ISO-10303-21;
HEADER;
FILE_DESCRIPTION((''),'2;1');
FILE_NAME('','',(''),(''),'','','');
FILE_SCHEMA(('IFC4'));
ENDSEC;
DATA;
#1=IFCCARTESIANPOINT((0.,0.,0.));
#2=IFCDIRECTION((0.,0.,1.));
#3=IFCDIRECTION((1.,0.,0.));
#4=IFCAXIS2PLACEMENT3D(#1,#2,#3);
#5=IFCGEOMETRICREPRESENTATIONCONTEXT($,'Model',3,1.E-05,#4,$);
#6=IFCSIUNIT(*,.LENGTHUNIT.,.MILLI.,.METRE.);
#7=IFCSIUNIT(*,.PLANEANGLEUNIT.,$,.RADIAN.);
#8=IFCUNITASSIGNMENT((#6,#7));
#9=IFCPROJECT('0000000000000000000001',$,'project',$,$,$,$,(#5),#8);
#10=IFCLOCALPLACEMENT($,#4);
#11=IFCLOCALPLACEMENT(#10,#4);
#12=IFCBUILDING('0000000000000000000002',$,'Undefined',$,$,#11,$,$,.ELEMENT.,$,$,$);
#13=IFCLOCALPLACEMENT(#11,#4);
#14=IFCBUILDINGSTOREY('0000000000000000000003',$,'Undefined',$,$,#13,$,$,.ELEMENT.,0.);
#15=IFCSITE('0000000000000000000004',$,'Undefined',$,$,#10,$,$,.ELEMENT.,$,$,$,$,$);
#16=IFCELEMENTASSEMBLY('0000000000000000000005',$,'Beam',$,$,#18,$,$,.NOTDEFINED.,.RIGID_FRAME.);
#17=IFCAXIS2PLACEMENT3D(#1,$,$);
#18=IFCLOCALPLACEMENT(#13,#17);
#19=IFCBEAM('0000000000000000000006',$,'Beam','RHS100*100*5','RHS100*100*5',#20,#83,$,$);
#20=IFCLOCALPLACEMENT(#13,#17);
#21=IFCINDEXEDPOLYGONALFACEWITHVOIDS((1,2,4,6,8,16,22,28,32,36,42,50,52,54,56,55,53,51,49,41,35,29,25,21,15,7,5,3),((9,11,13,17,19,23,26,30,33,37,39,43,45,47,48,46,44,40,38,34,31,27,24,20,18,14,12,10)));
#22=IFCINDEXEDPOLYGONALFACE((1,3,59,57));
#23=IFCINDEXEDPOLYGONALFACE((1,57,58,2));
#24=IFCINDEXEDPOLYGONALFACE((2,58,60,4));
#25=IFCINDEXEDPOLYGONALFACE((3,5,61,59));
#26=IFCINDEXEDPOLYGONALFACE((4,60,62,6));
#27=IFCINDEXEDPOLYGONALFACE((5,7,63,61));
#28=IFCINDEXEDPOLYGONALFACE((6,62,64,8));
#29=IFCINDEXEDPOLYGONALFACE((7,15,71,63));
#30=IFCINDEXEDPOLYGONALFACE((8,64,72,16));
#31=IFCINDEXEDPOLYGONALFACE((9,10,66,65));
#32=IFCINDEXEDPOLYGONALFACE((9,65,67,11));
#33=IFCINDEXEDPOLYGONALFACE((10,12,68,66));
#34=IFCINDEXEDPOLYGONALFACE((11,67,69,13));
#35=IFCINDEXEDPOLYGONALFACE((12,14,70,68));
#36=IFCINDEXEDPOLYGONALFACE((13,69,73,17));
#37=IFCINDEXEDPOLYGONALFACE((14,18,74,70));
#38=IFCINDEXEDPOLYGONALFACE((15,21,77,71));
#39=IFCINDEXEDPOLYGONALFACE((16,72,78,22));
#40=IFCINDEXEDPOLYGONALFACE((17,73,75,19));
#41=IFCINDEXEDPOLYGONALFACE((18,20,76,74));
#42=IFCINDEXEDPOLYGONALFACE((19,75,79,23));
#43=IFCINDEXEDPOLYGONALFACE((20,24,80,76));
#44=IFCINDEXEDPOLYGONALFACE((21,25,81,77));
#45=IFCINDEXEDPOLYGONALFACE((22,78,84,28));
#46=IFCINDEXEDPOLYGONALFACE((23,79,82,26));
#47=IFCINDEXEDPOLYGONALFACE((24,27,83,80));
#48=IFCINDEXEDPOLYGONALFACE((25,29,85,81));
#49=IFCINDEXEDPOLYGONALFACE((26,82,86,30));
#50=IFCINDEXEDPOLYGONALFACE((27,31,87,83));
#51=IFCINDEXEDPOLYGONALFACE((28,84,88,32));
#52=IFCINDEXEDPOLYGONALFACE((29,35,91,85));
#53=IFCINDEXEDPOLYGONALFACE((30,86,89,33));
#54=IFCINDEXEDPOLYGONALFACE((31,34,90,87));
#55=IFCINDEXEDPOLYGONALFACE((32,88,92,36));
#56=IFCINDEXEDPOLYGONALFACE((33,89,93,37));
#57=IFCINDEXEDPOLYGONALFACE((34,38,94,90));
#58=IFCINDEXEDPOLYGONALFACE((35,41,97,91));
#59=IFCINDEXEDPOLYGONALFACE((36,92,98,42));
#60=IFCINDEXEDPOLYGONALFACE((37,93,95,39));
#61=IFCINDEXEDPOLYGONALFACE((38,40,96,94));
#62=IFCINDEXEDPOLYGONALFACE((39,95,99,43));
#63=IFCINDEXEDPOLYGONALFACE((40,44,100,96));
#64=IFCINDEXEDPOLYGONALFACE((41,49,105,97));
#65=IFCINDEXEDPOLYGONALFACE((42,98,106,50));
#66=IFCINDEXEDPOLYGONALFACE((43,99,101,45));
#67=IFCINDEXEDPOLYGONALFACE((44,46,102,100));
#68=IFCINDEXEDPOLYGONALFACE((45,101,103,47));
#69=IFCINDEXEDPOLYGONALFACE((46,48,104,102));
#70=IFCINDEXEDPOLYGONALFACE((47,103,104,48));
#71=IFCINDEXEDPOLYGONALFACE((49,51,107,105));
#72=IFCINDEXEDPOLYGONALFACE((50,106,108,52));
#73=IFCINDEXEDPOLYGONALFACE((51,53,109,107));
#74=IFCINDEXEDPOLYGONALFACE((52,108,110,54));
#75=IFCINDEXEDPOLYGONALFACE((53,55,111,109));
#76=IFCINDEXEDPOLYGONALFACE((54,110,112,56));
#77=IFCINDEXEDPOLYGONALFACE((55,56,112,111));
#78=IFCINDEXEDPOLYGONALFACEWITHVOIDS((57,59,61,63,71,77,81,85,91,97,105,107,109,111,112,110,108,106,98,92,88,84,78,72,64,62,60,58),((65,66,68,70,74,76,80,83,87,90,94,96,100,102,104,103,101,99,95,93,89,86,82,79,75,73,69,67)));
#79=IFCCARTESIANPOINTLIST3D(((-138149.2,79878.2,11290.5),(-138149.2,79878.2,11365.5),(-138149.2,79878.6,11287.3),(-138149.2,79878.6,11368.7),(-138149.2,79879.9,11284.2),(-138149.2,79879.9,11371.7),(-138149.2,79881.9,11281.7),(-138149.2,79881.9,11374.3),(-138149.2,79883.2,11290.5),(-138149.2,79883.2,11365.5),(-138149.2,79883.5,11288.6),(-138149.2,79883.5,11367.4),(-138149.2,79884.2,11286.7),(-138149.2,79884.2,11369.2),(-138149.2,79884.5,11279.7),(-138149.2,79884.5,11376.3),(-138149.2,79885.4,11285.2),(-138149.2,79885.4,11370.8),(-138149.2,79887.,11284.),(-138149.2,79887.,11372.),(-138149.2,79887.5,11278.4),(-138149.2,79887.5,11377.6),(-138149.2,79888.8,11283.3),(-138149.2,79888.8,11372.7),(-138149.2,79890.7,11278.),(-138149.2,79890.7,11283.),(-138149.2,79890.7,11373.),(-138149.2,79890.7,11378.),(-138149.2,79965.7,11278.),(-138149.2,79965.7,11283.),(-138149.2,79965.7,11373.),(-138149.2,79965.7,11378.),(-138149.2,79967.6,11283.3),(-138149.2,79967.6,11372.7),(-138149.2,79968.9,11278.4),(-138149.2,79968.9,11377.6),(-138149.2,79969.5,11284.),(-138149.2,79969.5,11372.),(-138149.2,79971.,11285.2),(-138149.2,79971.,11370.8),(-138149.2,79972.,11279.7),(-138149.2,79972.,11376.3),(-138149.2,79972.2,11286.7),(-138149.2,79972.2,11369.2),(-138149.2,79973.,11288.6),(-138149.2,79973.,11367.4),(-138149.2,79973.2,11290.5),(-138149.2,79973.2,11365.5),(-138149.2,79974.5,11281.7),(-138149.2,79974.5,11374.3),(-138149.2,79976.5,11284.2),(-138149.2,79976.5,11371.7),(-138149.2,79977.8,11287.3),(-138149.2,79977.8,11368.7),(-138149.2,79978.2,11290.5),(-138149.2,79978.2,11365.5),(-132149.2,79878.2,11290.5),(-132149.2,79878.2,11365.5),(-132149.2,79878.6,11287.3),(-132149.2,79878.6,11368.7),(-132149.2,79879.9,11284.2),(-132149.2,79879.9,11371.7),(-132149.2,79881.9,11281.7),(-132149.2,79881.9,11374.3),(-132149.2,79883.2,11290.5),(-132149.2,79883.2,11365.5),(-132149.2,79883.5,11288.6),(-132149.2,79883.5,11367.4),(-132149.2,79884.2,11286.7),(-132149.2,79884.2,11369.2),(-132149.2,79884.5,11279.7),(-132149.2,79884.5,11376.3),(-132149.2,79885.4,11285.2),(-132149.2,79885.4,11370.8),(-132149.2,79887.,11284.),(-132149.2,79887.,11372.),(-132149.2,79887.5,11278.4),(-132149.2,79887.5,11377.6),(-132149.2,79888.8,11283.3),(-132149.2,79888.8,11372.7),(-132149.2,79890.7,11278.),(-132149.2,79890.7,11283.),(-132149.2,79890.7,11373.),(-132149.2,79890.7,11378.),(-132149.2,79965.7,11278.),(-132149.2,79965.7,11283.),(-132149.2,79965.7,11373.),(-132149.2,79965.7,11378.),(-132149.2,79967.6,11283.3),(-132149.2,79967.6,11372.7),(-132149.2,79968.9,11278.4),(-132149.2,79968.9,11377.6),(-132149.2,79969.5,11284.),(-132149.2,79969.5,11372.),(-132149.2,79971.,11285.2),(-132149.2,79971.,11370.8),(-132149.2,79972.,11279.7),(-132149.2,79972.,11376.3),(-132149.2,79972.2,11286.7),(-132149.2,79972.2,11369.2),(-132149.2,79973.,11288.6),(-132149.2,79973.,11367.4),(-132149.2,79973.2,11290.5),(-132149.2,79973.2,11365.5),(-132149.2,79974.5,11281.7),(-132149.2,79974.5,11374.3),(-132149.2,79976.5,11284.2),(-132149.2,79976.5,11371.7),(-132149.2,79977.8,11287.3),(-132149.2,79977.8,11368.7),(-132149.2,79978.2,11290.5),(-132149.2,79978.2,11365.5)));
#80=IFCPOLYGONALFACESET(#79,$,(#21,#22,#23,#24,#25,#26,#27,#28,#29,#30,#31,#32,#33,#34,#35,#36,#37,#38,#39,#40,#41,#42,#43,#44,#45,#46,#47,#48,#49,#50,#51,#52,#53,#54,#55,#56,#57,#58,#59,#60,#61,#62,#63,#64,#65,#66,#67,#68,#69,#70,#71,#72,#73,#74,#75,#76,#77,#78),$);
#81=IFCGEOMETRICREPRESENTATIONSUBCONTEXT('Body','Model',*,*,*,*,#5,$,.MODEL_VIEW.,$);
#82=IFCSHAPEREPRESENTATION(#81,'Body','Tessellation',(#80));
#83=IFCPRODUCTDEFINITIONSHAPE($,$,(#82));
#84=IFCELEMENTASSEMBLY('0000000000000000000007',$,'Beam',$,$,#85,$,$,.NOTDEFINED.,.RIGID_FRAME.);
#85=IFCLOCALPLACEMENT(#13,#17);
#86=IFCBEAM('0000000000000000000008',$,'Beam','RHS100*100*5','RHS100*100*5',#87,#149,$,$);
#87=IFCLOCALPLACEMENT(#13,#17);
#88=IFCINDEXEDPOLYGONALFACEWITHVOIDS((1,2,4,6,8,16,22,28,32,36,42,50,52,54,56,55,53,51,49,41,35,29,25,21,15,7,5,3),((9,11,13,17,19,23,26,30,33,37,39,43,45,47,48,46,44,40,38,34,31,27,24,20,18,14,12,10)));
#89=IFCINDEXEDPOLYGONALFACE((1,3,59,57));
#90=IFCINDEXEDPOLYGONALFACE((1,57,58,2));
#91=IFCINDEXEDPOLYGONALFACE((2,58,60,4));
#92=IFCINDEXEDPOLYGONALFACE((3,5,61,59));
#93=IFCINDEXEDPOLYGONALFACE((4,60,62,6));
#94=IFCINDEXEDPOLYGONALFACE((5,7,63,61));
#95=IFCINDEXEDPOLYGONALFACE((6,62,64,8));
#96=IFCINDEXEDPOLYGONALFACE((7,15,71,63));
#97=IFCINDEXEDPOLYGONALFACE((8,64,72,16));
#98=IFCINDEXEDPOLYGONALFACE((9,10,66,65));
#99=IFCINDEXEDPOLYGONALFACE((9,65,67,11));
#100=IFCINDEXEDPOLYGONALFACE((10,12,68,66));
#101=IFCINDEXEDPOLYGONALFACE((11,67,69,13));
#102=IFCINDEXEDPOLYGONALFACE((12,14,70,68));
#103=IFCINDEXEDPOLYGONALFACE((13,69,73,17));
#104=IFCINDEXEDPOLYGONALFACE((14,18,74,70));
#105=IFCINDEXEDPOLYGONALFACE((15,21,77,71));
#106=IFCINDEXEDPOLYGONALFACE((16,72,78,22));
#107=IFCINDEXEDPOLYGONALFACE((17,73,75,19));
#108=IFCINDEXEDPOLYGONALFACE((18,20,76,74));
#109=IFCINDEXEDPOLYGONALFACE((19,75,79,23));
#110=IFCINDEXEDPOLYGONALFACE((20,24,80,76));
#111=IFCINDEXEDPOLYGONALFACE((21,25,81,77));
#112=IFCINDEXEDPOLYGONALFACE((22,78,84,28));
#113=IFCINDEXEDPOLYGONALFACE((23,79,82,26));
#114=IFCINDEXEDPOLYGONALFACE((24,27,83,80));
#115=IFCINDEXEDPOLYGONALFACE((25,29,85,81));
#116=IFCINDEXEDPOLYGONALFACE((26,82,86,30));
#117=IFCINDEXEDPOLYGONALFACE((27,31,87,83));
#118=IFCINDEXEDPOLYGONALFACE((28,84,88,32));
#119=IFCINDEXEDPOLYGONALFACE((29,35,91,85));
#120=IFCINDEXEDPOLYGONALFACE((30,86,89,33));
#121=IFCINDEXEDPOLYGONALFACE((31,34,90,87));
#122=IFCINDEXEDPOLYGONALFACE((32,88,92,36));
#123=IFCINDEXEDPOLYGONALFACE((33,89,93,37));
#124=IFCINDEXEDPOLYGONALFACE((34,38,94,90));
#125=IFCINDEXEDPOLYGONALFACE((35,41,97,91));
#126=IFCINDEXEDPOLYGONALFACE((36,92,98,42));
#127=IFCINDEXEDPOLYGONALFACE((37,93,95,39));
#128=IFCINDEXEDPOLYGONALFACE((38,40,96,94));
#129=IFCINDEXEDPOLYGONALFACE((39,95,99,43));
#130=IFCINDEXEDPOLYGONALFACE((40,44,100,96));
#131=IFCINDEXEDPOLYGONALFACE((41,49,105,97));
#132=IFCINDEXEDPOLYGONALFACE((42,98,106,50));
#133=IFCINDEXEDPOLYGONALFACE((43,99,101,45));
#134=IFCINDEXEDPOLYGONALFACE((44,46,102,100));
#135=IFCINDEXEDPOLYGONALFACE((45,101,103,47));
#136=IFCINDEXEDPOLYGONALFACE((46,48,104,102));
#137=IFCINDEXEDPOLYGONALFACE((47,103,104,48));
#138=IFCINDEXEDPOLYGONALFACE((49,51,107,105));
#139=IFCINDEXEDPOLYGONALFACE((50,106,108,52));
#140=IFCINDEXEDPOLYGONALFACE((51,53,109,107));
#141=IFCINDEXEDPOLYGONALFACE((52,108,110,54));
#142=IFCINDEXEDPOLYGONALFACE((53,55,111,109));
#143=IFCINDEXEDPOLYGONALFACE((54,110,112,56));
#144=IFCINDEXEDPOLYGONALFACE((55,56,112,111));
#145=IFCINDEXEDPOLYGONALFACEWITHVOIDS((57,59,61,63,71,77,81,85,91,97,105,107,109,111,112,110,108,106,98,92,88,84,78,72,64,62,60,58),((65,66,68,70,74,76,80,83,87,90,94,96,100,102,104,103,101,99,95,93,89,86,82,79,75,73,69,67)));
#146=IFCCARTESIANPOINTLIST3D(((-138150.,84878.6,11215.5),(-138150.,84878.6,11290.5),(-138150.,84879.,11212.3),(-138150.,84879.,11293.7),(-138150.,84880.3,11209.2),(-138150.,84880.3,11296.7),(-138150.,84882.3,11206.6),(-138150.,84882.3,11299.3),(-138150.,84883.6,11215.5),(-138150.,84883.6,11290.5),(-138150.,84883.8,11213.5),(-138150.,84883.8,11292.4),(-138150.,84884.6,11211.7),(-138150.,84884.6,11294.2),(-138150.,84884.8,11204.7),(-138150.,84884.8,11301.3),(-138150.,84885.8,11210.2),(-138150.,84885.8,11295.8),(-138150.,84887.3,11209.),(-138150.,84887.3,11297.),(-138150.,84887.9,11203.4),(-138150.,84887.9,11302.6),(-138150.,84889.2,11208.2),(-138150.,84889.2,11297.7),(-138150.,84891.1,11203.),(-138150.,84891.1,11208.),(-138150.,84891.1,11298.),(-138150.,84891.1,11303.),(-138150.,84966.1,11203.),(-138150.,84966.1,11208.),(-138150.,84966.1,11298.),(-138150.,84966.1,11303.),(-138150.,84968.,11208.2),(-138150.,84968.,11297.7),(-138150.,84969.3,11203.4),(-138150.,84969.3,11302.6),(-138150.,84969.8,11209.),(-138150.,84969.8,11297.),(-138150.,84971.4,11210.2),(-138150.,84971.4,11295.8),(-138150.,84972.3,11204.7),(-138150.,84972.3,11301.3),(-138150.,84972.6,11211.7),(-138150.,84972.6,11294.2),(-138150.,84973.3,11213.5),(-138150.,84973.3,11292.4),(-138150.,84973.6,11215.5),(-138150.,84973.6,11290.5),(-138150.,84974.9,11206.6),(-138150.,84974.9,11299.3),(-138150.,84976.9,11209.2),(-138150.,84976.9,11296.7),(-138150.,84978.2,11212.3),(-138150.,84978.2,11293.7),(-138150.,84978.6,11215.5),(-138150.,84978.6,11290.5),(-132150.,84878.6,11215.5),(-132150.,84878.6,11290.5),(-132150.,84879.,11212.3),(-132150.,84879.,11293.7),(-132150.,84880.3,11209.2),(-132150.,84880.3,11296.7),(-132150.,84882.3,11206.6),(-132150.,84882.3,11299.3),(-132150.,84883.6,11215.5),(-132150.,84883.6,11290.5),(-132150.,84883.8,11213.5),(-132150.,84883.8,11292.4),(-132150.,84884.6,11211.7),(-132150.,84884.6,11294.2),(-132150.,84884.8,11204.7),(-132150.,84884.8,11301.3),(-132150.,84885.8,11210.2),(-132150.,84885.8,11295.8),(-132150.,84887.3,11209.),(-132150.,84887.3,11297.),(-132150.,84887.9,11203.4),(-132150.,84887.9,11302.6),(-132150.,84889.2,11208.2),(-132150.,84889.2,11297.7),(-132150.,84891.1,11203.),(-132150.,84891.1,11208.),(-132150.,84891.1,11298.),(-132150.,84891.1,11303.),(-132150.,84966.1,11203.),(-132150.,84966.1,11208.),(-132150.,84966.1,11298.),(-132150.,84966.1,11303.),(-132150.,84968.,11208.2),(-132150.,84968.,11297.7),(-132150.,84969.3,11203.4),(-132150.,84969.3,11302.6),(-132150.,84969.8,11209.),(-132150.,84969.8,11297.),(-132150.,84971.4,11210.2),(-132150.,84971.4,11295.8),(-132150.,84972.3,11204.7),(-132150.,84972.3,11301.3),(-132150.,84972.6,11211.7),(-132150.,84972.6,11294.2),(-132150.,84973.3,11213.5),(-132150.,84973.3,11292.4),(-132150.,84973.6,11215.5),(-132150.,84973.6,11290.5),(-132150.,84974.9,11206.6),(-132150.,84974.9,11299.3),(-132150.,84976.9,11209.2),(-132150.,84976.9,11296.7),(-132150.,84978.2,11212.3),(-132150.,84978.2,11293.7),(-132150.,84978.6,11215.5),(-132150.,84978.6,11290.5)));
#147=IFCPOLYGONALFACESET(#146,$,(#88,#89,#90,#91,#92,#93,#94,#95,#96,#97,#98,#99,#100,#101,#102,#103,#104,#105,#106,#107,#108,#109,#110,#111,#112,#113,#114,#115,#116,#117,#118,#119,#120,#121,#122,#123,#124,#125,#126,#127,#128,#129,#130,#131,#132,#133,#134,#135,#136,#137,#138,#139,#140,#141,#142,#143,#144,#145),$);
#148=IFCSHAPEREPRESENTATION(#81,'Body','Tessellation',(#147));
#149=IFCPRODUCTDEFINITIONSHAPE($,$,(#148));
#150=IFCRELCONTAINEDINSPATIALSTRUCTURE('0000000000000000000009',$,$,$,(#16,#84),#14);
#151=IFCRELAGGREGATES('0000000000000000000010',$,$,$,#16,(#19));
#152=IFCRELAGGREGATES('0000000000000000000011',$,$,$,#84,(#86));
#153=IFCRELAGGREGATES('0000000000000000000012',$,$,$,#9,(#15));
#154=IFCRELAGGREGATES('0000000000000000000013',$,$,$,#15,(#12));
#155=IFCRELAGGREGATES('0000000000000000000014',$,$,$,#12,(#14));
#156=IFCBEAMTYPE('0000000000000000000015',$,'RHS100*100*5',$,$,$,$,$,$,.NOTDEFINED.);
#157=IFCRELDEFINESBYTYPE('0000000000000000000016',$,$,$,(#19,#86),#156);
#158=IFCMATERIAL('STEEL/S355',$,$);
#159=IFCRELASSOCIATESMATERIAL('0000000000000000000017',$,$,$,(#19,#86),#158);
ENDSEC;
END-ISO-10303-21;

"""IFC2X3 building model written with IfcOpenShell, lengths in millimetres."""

from ifc_helpers import new_model, si_unit, frame, origin_with_axes, origin_2d_with_axis, place, context, subcontext, project, spatial, hollow_rectangle, extrude, material, type_object, element, aggregate, save


model = new_model("IFC2X3")

# Units and contexts
model_context = context("Model", 3, precision=1e-05, world=origin_with_axes())
body_context = subcontext(model_context, "Body", "Model", "MODEL_VIEW")
ifc_project = project(units=[si_unit("LENGTHUNIT", "METRE", prefix="MILLI"), si_unit("PLANEANGLEUNIT", "RADIAN")], contexts=[model_context])

# Site, building, storey
site_placement = place(None, origin_with_axes())
site = spatial("IfcSite", under=ifc_project, at=site_placement, Name="Undefined", CompositionType="ELEMENT")
building_placement = place(site_placement, origin_with_axes())
building = spatial("IfcBuilding", under=site, at=building_placement, Name="Undefined", CompositionType="ELEMENT")
storey_placement = place(building_placement, origin_with_axes())
storey = spatial("IfcBuildingStorey", under=building, at=storey_placement, Name="Undefined", CompositionType="ELEMENT", Elevation=0.0)

# Element assemblies, beams
ifc_material_1 = material(Name="STEEL/S355")
assembly_1_placement = place(storey_placement, origin_with_axes())
assembly_1 = element("IfcElementAssembly", 1, at=assembly_1_placement, inside=storey, Name="Beam", AssemblyPlace="NOTDEFINED", PredefinedType="RIGID_FRAME")
beam_type_1 = type_object("IfcBeamType", Name="RHS100*100*5", PredefinedType="NOTDEFINED")
beam_1_placement = place(assembly_1_placement, frame((-132149.2, 79928.2, 11328.0), z_axis=(0.0, 0.0, 1.0), x_axis=(-1.0, 0.0, 0.0)))
beam_1 = element("IfcBeam", 2, at=beam_1_placement, type_object=beam_type_1, material=ifc_material_1, Name="Beam", Description="RHS100*100*5", ObjectType="RHS100*100*5", context=body_context, shape_type="SweptSolid", body=[
    extrude(hollow_rectangle(XDim=100.0, YDim=100.0, WallThickness=5.0, InnerFilletRadius=7.5, OuterFilletRadius=12.5, at=origin_2d_with_axis()), frame((6000.0, 0.0, 0.0), z_axis=(-1.0, 0.0, 0.0), x_axis=(0.0, -1.0, 0.0)), (0.0, 0.0, 1.0), 6000.0),
])
aggregate(assembly_1, [beam_1])
assembly_2_placement = place(storey_placement, origin_with_axes())
assembly_2 = element("IfcElementAssembly", 3, at=assembly_2_placement, inside=storey, Name="Beam", AssemblyPlace="NOTDEFINED", PredefinedType="RIGID_FRAME")
beam_2_placement = place(assembly_2_placement, frame((-132150.0, 84928.6, 11253.0), z_axis=(0.0, 0.0, 1.0), x_axis=(-1.0, 0.0, 0.0)))
beam_2 = element("IfcBeam", 4, at=beam_2_placement, type_object=beam_type_1, material=ifc_material_1, Name="Beam", Description="RHS100*100*5", ObjectType="RHS100*100*5", context=body_context, shape_type="SweptSolid", body=[
    extrude(hollow_rectangle(XDim=100.0, YDim=100.0, WallThickness=5.0, InnerFilletRadius=7.5, OuterFilletRadius=12.5, at=origin_2d_with_axis()), frame((6000.0, 0.0, 0.0), z_axis=(-1.0, 0.0, 0.0), x_axis=(0.0, -1.0, 0.0)), (0.0, 0.0, 1.0), 6000.0),
])
aggregate(assembly_2, [beam_2])

save(model, "model.ifc")
